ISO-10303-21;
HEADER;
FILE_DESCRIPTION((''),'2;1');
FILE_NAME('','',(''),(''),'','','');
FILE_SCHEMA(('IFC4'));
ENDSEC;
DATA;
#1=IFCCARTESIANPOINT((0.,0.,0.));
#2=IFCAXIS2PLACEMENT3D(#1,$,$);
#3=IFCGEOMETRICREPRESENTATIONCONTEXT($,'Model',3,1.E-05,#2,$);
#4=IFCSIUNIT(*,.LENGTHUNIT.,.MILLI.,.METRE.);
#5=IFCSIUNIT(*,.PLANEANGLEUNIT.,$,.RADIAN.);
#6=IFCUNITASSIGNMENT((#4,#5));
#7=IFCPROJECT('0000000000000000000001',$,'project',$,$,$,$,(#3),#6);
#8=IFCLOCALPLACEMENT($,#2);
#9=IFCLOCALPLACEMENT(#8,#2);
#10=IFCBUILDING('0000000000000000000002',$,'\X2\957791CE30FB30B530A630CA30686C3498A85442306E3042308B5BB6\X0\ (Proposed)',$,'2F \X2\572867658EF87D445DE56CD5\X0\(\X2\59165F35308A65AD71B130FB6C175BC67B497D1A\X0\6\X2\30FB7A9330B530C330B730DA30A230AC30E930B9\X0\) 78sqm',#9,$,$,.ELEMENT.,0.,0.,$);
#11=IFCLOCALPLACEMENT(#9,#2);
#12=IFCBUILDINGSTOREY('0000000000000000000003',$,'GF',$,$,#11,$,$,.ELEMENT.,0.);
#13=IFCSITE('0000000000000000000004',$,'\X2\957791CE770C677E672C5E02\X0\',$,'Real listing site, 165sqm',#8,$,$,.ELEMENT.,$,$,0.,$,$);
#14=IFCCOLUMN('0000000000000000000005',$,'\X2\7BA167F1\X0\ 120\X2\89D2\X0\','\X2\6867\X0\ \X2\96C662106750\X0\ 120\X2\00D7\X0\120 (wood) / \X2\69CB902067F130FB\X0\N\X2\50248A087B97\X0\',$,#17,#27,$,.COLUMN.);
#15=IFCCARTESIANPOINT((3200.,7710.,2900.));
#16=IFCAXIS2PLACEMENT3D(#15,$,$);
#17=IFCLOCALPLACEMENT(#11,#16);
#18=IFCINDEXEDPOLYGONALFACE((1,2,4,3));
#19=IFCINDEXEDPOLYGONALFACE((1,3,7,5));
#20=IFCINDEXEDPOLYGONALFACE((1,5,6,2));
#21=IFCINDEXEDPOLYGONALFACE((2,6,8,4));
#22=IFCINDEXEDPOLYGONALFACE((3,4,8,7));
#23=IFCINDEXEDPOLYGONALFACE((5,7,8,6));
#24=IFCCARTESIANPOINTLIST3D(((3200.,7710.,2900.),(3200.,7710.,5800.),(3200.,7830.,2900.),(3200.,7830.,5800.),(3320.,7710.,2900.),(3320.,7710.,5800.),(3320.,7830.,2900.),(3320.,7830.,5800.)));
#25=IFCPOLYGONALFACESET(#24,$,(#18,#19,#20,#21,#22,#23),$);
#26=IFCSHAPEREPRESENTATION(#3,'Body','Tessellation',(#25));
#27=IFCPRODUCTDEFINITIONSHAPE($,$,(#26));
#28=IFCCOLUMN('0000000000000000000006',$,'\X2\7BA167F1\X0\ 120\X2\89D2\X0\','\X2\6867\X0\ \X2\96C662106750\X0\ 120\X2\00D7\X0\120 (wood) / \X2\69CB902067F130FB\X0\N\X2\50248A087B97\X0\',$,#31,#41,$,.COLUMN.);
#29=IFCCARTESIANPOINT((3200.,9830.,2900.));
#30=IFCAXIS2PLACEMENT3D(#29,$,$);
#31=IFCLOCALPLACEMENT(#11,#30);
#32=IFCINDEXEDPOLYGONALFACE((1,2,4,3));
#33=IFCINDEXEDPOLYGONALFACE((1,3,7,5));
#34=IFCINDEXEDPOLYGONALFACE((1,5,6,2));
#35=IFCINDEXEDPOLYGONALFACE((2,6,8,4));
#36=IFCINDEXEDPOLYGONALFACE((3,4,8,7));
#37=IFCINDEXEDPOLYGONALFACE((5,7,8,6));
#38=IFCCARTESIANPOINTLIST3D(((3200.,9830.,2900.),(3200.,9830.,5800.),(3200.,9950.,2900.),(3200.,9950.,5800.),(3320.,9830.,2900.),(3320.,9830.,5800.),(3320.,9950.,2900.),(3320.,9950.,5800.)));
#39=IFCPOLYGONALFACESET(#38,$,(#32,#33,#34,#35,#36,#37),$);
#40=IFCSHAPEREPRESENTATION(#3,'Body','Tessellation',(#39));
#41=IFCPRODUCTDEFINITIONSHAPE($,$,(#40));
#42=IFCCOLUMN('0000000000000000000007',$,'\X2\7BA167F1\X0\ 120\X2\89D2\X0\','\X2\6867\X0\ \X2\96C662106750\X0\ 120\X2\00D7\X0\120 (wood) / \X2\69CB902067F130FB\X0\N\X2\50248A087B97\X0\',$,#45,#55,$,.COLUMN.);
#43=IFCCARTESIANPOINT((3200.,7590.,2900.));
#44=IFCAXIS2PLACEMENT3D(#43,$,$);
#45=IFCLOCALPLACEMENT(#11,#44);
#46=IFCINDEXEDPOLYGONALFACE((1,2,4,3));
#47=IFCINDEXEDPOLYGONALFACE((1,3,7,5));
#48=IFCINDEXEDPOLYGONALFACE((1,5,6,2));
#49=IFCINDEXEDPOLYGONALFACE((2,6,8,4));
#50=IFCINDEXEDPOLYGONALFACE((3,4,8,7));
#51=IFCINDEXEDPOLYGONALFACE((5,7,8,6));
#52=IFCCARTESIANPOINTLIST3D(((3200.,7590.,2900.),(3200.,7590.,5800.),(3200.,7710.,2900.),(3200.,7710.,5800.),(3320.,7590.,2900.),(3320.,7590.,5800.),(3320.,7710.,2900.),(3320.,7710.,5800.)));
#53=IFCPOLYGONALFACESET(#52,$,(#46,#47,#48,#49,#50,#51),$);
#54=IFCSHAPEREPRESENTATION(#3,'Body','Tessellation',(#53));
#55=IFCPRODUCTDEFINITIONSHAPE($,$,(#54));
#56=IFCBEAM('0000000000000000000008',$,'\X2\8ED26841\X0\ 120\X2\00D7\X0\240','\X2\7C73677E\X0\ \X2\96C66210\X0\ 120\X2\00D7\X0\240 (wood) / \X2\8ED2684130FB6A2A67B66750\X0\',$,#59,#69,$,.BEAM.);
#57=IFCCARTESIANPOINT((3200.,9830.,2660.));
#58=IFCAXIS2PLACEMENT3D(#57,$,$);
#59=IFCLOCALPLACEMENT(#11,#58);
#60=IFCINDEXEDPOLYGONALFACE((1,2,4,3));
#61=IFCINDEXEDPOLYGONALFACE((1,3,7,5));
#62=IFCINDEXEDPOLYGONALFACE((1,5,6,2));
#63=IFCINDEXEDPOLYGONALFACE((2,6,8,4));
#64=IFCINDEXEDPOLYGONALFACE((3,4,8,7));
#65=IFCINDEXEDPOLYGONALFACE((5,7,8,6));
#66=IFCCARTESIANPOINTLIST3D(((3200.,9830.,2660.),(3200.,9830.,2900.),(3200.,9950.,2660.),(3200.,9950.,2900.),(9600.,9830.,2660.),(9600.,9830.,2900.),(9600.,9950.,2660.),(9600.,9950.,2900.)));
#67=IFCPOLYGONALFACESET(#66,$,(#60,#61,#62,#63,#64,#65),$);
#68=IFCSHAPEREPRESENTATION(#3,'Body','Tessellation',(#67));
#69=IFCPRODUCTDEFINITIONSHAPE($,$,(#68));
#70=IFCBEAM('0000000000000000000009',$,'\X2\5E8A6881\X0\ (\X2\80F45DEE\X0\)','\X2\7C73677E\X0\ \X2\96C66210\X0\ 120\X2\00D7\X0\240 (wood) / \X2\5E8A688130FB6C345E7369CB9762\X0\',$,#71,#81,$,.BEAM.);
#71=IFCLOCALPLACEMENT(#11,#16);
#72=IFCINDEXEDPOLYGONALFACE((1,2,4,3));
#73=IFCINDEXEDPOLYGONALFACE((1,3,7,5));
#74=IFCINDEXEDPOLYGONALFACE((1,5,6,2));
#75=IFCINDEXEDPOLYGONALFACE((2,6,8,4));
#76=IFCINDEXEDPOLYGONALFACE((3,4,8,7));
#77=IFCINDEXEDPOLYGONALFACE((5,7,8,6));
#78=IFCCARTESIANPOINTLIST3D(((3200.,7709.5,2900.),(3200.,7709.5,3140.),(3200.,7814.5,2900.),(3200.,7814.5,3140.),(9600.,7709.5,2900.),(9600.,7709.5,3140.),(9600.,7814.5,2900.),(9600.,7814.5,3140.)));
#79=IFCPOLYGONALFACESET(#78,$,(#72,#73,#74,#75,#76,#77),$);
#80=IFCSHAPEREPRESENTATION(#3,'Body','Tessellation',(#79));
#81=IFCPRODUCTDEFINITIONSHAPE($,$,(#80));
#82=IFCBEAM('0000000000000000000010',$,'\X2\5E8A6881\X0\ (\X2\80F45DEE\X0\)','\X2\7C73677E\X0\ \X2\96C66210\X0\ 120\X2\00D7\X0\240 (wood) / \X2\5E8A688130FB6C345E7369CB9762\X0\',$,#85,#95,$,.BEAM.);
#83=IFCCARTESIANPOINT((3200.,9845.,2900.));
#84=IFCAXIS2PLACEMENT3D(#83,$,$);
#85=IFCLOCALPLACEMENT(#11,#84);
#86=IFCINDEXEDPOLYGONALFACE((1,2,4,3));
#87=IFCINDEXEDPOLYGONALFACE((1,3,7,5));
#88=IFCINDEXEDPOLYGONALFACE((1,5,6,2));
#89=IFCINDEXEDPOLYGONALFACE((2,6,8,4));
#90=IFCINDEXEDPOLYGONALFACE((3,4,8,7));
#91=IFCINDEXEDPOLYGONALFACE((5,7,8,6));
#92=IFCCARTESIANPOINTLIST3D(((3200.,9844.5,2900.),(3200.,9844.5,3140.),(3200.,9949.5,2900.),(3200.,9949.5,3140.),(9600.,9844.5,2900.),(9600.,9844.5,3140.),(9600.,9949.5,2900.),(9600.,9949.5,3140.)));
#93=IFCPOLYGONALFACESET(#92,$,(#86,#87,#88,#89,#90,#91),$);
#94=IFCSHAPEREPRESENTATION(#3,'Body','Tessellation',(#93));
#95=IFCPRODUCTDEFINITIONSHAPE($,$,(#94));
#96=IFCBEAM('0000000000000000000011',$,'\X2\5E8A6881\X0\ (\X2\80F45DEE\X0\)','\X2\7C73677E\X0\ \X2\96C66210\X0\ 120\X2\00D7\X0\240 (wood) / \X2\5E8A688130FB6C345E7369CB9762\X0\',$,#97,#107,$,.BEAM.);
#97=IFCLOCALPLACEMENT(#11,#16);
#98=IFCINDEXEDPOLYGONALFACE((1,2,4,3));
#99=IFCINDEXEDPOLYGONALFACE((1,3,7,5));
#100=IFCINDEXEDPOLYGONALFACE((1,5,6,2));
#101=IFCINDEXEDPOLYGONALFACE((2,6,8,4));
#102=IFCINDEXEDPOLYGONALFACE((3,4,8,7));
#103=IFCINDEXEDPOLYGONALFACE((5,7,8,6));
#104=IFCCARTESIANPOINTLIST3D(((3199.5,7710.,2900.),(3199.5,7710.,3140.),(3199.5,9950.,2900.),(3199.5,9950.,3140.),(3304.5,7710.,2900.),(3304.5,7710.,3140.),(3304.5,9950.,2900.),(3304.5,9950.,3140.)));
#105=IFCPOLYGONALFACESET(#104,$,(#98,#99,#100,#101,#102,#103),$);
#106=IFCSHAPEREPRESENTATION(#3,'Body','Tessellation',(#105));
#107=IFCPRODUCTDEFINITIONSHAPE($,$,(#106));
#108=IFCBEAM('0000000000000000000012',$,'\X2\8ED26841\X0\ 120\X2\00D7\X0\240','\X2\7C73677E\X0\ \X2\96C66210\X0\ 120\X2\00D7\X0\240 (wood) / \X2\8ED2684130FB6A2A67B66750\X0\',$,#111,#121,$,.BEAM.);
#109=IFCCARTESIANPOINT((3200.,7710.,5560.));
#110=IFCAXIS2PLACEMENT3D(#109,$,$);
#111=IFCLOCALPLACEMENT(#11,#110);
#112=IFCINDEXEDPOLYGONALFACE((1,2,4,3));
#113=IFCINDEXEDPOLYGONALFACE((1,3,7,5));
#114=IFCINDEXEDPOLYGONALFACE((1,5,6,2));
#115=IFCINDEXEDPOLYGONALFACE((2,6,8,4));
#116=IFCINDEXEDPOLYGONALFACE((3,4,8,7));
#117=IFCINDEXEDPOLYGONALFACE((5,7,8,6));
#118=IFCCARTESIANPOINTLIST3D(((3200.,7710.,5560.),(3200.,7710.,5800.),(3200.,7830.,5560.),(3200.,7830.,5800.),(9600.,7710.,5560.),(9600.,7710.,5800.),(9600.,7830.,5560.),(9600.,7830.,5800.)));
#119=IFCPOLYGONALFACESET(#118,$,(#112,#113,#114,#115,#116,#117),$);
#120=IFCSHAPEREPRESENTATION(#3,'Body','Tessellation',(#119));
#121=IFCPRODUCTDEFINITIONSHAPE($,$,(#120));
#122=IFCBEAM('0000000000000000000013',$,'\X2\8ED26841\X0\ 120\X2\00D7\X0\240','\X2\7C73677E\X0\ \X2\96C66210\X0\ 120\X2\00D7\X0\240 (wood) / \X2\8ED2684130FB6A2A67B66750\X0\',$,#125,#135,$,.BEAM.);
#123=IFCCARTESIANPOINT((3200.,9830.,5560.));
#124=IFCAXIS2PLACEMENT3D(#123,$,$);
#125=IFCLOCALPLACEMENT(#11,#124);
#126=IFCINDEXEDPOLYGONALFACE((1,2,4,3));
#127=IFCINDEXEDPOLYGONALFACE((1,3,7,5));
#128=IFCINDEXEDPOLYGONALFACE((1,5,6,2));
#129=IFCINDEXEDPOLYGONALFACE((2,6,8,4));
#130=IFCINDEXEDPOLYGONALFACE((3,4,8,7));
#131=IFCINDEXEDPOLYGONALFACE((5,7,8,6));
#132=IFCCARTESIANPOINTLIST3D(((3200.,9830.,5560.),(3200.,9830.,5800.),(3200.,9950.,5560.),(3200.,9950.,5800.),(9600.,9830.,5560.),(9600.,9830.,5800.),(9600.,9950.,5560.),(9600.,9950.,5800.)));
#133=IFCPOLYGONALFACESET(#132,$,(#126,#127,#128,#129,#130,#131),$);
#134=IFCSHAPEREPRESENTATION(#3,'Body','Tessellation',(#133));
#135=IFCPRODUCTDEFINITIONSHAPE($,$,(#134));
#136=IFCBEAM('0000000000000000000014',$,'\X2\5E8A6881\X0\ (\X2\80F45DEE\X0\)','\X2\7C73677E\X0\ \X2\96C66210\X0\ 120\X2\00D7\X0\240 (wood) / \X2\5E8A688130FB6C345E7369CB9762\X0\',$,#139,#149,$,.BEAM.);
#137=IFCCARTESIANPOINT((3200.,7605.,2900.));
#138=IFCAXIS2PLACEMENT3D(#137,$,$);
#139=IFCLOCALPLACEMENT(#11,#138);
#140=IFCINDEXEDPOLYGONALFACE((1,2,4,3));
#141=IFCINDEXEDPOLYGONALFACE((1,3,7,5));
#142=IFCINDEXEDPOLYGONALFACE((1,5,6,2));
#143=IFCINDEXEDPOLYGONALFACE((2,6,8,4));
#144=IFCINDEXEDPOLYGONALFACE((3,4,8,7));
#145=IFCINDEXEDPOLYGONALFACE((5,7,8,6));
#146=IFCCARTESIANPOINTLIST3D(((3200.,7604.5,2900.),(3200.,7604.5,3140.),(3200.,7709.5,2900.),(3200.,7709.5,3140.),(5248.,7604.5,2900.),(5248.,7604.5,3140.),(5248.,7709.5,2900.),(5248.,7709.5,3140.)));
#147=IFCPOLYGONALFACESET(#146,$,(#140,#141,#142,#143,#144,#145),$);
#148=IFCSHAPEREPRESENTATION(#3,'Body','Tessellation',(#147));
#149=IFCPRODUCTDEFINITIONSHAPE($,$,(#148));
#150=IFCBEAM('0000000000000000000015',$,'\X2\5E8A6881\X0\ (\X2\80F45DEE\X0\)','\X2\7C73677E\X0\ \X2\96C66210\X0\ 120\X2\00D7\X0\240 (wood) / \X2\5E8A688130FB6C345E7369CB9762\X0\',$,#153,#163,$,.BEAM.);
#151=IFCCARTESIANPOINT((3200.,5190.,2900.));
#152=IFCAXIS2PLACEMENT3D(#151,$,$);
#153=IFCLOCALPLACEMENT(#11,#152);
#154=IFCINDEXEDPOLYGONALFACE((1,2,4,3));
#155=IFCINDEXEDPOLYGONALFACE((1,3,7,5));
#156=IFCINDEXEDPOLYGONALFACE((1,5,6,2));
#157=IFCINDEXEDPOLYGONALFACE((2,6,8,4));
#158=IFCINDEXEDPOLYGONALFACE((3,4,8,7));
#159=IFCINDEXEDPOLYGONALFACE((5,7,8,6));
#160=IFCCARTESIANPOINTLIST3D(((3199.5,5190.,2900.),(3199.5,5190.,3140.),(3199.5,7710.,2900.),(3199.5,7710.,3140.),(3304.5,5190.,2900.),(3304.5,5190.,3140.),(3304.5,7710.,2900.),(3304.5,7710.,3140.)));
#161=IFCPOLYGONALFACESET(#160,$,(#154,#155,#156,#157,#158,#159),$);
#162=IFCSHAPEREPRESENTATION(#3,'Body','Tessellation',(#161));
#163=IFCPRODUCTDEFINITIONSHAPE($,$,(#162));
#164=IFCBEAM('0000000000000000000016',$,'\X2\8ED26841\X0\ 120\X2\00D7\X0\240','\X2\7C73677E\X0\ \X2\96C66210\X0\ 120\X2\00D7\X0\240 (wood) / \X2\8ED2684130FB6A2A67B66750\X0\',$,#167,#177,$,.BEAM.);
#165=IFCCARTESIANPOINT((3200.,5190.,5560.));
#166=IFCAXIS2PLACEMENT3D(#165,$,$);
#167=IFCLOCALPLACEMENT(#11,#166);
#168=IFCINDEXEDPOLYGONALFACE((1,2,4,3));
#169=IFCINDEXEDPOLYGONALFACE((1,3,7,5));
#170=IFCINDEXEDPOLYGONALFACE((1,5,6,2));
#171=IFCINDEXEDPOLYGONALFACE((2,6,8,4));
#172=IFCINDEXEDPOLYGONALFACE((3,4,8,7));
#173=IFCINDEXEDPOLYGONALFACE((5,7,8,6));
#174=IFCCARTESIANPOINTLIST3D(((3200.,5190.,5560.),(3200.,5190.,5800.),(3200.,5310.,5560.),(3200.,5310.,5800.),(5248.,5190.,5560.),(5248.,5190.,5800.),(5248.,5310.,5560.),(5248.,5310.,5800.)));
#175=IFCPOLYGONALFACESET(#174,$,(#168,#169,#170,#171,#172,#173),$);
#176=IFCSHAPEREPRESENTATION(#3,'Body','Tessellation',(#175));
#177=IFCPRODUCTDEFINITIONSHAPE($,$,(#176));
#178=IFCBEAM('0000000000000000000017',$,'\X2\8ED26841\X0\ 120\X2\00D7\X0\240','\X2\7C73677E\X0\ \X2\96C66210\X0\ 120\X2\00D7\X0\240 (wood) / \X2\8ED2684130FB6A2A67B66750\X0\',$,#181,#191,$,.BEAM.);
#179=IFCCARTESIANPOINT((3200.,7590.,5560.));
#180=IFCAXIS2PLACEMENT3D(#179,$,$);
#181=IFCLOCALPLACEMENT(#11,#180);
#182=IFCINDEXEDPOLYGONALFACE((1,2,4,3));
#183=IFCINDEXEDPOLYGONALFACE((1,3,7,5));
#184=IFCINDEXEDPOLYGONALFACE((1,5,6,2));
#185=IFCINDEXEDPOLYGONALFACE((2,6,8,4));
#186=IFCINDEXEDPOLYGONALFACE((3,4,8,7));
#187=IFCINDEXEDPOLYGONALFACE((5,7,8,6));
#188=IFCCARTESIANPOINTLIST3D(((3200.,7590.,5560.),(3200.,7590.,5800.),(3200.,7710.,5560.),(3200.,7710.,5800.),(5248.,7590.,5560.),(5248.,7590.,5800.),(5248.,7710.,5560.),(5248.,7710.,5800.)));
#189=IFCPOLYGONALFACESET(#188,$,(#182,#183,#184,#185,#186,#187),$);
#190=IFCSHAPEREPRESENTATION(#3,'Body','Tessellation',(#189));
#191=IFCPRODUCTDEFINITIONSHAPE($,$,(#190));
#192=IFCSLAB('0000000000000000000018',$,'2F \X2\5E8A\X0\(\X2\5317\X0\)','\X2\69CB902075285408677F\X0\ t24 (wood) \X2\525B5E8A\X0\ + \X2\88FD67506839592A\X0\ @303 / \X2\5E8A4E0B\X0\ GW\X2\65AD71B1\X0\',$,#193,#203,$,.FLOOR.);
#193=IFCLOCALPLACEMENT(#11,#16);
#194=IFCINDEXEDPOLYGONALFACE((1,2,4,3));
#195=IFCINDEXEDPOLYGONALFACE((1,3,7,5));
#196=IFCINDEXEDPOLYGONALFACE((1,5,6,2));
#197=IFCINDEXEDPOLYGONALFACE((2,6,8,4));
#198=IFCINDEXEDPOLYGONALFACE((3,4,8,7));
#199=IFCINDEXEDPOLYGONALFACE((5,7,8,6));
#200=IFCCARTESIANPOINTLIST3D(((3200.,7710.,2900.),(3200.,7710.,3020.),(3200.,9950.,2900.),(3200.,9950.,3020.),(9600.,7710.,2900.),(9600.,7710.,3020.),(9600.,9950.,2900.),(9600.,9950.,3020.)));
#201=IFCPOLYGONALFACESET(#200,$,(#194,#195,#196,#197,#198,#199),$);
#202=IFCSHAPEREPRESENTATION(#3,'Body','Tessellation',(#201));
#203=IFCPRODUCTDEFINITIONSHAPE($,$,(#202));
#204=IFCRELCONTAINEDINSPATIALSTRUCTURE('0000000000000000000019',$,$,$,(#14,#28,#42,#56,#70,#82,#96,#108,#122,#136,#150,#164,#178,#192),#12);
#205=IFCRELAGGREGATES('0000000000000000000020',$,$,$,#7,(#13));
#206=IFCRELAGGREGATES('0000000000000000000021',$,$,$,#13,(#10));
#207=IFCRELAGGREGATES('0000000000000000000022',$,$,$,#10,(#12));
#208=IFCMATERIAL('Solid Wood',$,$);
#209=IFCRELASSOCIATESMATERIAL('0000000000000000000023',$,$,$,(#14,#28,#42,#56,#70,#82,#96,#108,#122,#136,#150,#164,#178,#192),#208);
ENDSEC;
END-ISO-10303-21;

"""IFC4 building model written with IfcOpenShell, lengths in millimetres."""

from ifc_helpers import new_model, si_unit, frame, frame_2d, origin, place, context, project, spatial, rectangle, extrude, material, element, save


model = new_model("IFC4")

# Units and contexts
model_context = context("Model", 3, precision=1e-05, world=origin())
ifc_project = project(units=[si_unit("LENGTHUNIT", "METRE", prefix="MILLI"), si_unit("PLANEANGLEUNIT", "RADIAN")], contexts=[model_context])

# Site, building, storey
site_placement = place(None, origin())
site = spatial("IfcSite", under=ifc_project, at=site_placement, Name="長野県松本市", ObjectType="Real listing site, 165sqm", CompositionType="ELEMENT", RefElevation=0.0)
building_placement = place(site_placement, origin())
building = spatial("IfcBuilding", under=site, at=building_placement, Name="長野・サウナと水風呂のある家 (Proposed)", ObjectType="2F 在来軸組工法(外張り断熱・気密等級6・窓サッシペアガラス) 78sqm", CompositionType="ELEMENT", ElevationOfRefHeight=0.0, ElevationOfTerrain=0.0)
storey_placement = place(building_placement, origin())
storey = spatial("IfcBuildingStorey", under=building, at=storey_placement, Name="GF", CompositionType="ELEMENT", Elevation=0.0)

# Columns
ifc_material_1 = material(Name="Solid Wood")
column_1_placement = place(storey_placement, frame((3200.0, 7710.0, 2900.0)))
element("IfcColumn", 1, at=column_1_placement, inside=storey, material=ifc_material_1, Name="管柱 120角", Description="桧 集成材 120×120 (wood) / 構造柱・N値計算", PredefinedType="COLUMN", context=model_context, shape_type="SweptSolid", body=[
    extrude(rectangle(XDim=120.0, YDim=120.0, at=frame_2d((60.0, 60.0))), frame((3200.0, 7710.0, 2900.0)), (0.0, 0.0, 1.0), 2900.0),
])
column_2_placement = place(storey_placement, frame((3200.0, 9830.0, 2900.0)))
element("IfcColumn", 2, at=column_2_placement, inside=storey, material=ifc_material_1, Name="管柱 120角", Description="桧 集成材 120×120 (wood) / 構造柱・N値計算", PredefinedType="COLUMN", context=model_context, shape_type="SweptSolid", body=[
    extrude(rectangle(XDim=120.0, YDim=120.0, at=frame_2d((60.0, 60.0))), frame((3200.0, 9830.0, 2900.0)), (0.0, 0.0, 1.0), 2900.0),
])
column_3_placement = place(storey_placement, frame((3200.0, 7590.0, 2900.0)))
element("IfcColumn", 3, at=column_3_placement, inside=storey, material=ifc_material_1, Name="管柱 120角", Description="桧 集成材 120×120 (wood) / 構造柱・N値計算", PredefinedType="COLUMN", context=model_context, shape_type="SweptSolid", body=[
    extrude(rectangle(XDim=120.0, YDim=120.0, at=frame_2d((60.0, 60.0))), frame((3200.0, 7590.0, 2900.0)), (0.0, 0.0, 1.0), 2900.0),
])

# Beams
beam_1_placement = place(storey_placement, frame((3200.0, 9830.0, 2660.0)))
element("IfcBeam", 4, at=beam_1_placement, inside=storey, material=ifc_material_1, Name="軒桁 120×240", Description="米松 集成 120×240 (wood) / 軒桁・横架材", PredefinedType="BEAM", context=model_context, shape_type="SweptSolid", body=[
    extrude(rectangle(XDim=6400.0, YDim=120.0, at=frame_2d((3200.0, 60.0))), frame((3200.0, 9830.0, 2660.0)), (0.0, 0.0, 1.0), 240.0),
])
beam_2_placement = place(storey_placement, frame((3200.0, 7710.0, 2900.0)))
element("IfcBeam", 5, at=beam_2_placement, inside=storey, material=ifc_material_1, Name="床梁 (胴差)", Description="米松 集成 120×240 (wood) / 床梁・水平構面", PredefinedType="BEAM", context=model_context, shape_type="SweptSolid", body=[
    extrude(rectangle(XDim=6400.0, YDim=105.0, at=frame_2d((3200.0, 52.0))), frame((3200.0, 7710.0, 2900.0)), (0.0, 0.0, 1.0), 240.0),
])
beam_3_placement = place(storey_placement, frame((3200.0, 9845.0, 2900.0)))
element("IfcBeam", 6, at=beam_3_placement, inside=storey, material=ifc_material_1, Name="床梁 (胴差)", Description="米松 集成 120×240 (wood) / 床梁・水平構面", PredefinedType="BEAM", context=model_context, shape_type="SweptSolid", body=[
    extrude(rectangle(XDim=6400.0, YDim=105.0, at=frame_2d((3200.0, 52.0))), frame((3200.0, 9845.0, 2900.0)), (0.0, 0.0, 1.0), 240.0),
])
beam_4_placement = place(storey_placement, frame((3200.0, 7710.0, 2900.0)))
element("IfcBeam", 7, at=beam_4_placement, inside=storey, material=ifc_material_1, Name="床梁 (胴差)", Description="米松 集成 120×240 (wood) / 床梁・水平構面", PredefinedType="BEAM", context=model_context, shape_type="SweptSolid", body=[
    extrude(rectangle(XDim=105.0, YDim=2240.0, at=frame_2d((52.0, 1120.0))), frame((3200.0, 7710.0, 2900.0)), (0.0, 0.0, 1.0), 240.0),
])
beam_5_placement = place(storey_placement, frame((3200.0, 7710.0, 5560.0)))
element("IfcBeam", 8, at=beam_5_placement, inside=storey, material=ifc_material_1, Name="軒桁 120×240", Description="米松 集成 120×240 (wood) / 軒桁・横架材", PredefinedType="BEAM", context=model_context, shape_type="SweptSolid", body=[
    extrude(rectangle(XDim=6400.0, YDim=120.0, at=frame_2d((3200.0, 60.0))), frame((3200.0, 7710.0, 5560.0)), (0.0, 0.0, 1.0), 240.0),
])
beam_6_placement = place(storey_placement, frame((3200.0, 9830.0, 5560.0)))
element("IfcBeam", 9, at=beam_6_placement, inside=storey, material=ifc_material_1, Name="軒桁 120×240", Description="米松 集成 120×240 (wood) / 軒桁・横架材", PredefinedType="BEAM", context=model_context, shape_type="SweptSolid", body=[
    extrude(rectangle(XDim=6400.0, YDim=120.0, at=frame_2d((3200.0, 60.0))), frame((3200.0, 9830.0, 5560.0)), (0.0, 0.0, 1.0), 240.0),
])
beam_7_placement = place(storey_placement, frame((3200.0, 7605.0, 2900.0)))
element("IfcBeam", 10, at=beam_7_placement, inside=storey, material=ifc_material_1, Name="床梁 (胴差)", Description="米松 集成 120×240 (wood) / 床梁・水平構面", PredefinedType="BEAM", context=model_context, shape_type="SweptSolid", body=[
    extrude(rectangle(XDim=2048.0, YDim=105.0, at=frame_2d((1024.0, 52.0))), frame((3200.0, 7605.0, 2900.0)), (0.0, 0.0, 1.0), 240.0),
])
beam_8_placement = place(storey_placement, frame((3200.0, 5190.0, 2900.0)))
element("IfcBeam", 11, at=beam_8_placement, inside=storey, material=ifc_material_1, Name="床梁 (胴差)", Description="米松 集成 120×240 (wood) / 床梁・水平構面", PredefinedType="BEAM", context=model_context, shape_type="SweptSolid", body=[
    extrude(rectangle(XDim=105.0, YDim=2520.0, at=frame_2d((52.0, 1260.0))), frame((3200.0, 5190.0, 2900.0)), (0.0, 0.0, 1.0), 240.0),
])
beam_9_placement = place(storey_placement, frame((3200.0, 5190.0, 5560.0)))
element("IfcBeam", 12, at=beam_9_placement, inside=storey, material=ifc_material_1, Name="軒桁 120×240", Description="米松 集成 120×240 (wood) / 軒桁・横架材", PredefinedType="BEAM", context=model_context, shape_type="SweptSolid", body=[
    extrude(rectangle(XDim=2048.0, YDim=120.0, at=frame_2d((1024.0, 60.0))), frame((3200.0, 5190.0, 5560.0)), (0.0, 0.0, 1.0), 240.0),
])
beam_10_placement = place(storey_placement, frame((3200.0, 7590.0, 5560.0)))
element("IfcBeam", 13, at=beam_10_placement, inside=storey, material=ifc_material_1, Name="軒桁 120×240", Description="米松 集成 120×240 (wood) / 軒桁・横架材", PredefinedType="BEAM", context=model_context, shape_type="SweptSolid", body=[
    extrude(rectangle(XDim=2048.0, YDim=120.0, at=frame_2d((1024.0, 60.0))), frame((3200.0, 7590.0, 5560.0)), (0.0, 0.0, 1.0), 240.0),
])

# Slab
slab_placement = place(storey_placement, frame((3200.0, 7710.0, 2900.0)))
element("IfcSlab", 14, at=slab_placement, inside=storey, material=ifc_material_1, Name="2F 床(北)", Description="構造用合板 t24 (wood) 剛床 + 製材根太 @303 / 床下 GW断熱", PredefinedType="FLOOR", context=model_context, shape_type="SweptSolid", body=[
    extrude(rectangle(XDim=6400.0, YDim=2240.0, at=frame_2d((3200.0, 1120.0))), frame((3200.0, 7710.0, 2900.0)), (0.0, 0.0, 1.0), 120.0),
])

save(model, "model.ifc")
